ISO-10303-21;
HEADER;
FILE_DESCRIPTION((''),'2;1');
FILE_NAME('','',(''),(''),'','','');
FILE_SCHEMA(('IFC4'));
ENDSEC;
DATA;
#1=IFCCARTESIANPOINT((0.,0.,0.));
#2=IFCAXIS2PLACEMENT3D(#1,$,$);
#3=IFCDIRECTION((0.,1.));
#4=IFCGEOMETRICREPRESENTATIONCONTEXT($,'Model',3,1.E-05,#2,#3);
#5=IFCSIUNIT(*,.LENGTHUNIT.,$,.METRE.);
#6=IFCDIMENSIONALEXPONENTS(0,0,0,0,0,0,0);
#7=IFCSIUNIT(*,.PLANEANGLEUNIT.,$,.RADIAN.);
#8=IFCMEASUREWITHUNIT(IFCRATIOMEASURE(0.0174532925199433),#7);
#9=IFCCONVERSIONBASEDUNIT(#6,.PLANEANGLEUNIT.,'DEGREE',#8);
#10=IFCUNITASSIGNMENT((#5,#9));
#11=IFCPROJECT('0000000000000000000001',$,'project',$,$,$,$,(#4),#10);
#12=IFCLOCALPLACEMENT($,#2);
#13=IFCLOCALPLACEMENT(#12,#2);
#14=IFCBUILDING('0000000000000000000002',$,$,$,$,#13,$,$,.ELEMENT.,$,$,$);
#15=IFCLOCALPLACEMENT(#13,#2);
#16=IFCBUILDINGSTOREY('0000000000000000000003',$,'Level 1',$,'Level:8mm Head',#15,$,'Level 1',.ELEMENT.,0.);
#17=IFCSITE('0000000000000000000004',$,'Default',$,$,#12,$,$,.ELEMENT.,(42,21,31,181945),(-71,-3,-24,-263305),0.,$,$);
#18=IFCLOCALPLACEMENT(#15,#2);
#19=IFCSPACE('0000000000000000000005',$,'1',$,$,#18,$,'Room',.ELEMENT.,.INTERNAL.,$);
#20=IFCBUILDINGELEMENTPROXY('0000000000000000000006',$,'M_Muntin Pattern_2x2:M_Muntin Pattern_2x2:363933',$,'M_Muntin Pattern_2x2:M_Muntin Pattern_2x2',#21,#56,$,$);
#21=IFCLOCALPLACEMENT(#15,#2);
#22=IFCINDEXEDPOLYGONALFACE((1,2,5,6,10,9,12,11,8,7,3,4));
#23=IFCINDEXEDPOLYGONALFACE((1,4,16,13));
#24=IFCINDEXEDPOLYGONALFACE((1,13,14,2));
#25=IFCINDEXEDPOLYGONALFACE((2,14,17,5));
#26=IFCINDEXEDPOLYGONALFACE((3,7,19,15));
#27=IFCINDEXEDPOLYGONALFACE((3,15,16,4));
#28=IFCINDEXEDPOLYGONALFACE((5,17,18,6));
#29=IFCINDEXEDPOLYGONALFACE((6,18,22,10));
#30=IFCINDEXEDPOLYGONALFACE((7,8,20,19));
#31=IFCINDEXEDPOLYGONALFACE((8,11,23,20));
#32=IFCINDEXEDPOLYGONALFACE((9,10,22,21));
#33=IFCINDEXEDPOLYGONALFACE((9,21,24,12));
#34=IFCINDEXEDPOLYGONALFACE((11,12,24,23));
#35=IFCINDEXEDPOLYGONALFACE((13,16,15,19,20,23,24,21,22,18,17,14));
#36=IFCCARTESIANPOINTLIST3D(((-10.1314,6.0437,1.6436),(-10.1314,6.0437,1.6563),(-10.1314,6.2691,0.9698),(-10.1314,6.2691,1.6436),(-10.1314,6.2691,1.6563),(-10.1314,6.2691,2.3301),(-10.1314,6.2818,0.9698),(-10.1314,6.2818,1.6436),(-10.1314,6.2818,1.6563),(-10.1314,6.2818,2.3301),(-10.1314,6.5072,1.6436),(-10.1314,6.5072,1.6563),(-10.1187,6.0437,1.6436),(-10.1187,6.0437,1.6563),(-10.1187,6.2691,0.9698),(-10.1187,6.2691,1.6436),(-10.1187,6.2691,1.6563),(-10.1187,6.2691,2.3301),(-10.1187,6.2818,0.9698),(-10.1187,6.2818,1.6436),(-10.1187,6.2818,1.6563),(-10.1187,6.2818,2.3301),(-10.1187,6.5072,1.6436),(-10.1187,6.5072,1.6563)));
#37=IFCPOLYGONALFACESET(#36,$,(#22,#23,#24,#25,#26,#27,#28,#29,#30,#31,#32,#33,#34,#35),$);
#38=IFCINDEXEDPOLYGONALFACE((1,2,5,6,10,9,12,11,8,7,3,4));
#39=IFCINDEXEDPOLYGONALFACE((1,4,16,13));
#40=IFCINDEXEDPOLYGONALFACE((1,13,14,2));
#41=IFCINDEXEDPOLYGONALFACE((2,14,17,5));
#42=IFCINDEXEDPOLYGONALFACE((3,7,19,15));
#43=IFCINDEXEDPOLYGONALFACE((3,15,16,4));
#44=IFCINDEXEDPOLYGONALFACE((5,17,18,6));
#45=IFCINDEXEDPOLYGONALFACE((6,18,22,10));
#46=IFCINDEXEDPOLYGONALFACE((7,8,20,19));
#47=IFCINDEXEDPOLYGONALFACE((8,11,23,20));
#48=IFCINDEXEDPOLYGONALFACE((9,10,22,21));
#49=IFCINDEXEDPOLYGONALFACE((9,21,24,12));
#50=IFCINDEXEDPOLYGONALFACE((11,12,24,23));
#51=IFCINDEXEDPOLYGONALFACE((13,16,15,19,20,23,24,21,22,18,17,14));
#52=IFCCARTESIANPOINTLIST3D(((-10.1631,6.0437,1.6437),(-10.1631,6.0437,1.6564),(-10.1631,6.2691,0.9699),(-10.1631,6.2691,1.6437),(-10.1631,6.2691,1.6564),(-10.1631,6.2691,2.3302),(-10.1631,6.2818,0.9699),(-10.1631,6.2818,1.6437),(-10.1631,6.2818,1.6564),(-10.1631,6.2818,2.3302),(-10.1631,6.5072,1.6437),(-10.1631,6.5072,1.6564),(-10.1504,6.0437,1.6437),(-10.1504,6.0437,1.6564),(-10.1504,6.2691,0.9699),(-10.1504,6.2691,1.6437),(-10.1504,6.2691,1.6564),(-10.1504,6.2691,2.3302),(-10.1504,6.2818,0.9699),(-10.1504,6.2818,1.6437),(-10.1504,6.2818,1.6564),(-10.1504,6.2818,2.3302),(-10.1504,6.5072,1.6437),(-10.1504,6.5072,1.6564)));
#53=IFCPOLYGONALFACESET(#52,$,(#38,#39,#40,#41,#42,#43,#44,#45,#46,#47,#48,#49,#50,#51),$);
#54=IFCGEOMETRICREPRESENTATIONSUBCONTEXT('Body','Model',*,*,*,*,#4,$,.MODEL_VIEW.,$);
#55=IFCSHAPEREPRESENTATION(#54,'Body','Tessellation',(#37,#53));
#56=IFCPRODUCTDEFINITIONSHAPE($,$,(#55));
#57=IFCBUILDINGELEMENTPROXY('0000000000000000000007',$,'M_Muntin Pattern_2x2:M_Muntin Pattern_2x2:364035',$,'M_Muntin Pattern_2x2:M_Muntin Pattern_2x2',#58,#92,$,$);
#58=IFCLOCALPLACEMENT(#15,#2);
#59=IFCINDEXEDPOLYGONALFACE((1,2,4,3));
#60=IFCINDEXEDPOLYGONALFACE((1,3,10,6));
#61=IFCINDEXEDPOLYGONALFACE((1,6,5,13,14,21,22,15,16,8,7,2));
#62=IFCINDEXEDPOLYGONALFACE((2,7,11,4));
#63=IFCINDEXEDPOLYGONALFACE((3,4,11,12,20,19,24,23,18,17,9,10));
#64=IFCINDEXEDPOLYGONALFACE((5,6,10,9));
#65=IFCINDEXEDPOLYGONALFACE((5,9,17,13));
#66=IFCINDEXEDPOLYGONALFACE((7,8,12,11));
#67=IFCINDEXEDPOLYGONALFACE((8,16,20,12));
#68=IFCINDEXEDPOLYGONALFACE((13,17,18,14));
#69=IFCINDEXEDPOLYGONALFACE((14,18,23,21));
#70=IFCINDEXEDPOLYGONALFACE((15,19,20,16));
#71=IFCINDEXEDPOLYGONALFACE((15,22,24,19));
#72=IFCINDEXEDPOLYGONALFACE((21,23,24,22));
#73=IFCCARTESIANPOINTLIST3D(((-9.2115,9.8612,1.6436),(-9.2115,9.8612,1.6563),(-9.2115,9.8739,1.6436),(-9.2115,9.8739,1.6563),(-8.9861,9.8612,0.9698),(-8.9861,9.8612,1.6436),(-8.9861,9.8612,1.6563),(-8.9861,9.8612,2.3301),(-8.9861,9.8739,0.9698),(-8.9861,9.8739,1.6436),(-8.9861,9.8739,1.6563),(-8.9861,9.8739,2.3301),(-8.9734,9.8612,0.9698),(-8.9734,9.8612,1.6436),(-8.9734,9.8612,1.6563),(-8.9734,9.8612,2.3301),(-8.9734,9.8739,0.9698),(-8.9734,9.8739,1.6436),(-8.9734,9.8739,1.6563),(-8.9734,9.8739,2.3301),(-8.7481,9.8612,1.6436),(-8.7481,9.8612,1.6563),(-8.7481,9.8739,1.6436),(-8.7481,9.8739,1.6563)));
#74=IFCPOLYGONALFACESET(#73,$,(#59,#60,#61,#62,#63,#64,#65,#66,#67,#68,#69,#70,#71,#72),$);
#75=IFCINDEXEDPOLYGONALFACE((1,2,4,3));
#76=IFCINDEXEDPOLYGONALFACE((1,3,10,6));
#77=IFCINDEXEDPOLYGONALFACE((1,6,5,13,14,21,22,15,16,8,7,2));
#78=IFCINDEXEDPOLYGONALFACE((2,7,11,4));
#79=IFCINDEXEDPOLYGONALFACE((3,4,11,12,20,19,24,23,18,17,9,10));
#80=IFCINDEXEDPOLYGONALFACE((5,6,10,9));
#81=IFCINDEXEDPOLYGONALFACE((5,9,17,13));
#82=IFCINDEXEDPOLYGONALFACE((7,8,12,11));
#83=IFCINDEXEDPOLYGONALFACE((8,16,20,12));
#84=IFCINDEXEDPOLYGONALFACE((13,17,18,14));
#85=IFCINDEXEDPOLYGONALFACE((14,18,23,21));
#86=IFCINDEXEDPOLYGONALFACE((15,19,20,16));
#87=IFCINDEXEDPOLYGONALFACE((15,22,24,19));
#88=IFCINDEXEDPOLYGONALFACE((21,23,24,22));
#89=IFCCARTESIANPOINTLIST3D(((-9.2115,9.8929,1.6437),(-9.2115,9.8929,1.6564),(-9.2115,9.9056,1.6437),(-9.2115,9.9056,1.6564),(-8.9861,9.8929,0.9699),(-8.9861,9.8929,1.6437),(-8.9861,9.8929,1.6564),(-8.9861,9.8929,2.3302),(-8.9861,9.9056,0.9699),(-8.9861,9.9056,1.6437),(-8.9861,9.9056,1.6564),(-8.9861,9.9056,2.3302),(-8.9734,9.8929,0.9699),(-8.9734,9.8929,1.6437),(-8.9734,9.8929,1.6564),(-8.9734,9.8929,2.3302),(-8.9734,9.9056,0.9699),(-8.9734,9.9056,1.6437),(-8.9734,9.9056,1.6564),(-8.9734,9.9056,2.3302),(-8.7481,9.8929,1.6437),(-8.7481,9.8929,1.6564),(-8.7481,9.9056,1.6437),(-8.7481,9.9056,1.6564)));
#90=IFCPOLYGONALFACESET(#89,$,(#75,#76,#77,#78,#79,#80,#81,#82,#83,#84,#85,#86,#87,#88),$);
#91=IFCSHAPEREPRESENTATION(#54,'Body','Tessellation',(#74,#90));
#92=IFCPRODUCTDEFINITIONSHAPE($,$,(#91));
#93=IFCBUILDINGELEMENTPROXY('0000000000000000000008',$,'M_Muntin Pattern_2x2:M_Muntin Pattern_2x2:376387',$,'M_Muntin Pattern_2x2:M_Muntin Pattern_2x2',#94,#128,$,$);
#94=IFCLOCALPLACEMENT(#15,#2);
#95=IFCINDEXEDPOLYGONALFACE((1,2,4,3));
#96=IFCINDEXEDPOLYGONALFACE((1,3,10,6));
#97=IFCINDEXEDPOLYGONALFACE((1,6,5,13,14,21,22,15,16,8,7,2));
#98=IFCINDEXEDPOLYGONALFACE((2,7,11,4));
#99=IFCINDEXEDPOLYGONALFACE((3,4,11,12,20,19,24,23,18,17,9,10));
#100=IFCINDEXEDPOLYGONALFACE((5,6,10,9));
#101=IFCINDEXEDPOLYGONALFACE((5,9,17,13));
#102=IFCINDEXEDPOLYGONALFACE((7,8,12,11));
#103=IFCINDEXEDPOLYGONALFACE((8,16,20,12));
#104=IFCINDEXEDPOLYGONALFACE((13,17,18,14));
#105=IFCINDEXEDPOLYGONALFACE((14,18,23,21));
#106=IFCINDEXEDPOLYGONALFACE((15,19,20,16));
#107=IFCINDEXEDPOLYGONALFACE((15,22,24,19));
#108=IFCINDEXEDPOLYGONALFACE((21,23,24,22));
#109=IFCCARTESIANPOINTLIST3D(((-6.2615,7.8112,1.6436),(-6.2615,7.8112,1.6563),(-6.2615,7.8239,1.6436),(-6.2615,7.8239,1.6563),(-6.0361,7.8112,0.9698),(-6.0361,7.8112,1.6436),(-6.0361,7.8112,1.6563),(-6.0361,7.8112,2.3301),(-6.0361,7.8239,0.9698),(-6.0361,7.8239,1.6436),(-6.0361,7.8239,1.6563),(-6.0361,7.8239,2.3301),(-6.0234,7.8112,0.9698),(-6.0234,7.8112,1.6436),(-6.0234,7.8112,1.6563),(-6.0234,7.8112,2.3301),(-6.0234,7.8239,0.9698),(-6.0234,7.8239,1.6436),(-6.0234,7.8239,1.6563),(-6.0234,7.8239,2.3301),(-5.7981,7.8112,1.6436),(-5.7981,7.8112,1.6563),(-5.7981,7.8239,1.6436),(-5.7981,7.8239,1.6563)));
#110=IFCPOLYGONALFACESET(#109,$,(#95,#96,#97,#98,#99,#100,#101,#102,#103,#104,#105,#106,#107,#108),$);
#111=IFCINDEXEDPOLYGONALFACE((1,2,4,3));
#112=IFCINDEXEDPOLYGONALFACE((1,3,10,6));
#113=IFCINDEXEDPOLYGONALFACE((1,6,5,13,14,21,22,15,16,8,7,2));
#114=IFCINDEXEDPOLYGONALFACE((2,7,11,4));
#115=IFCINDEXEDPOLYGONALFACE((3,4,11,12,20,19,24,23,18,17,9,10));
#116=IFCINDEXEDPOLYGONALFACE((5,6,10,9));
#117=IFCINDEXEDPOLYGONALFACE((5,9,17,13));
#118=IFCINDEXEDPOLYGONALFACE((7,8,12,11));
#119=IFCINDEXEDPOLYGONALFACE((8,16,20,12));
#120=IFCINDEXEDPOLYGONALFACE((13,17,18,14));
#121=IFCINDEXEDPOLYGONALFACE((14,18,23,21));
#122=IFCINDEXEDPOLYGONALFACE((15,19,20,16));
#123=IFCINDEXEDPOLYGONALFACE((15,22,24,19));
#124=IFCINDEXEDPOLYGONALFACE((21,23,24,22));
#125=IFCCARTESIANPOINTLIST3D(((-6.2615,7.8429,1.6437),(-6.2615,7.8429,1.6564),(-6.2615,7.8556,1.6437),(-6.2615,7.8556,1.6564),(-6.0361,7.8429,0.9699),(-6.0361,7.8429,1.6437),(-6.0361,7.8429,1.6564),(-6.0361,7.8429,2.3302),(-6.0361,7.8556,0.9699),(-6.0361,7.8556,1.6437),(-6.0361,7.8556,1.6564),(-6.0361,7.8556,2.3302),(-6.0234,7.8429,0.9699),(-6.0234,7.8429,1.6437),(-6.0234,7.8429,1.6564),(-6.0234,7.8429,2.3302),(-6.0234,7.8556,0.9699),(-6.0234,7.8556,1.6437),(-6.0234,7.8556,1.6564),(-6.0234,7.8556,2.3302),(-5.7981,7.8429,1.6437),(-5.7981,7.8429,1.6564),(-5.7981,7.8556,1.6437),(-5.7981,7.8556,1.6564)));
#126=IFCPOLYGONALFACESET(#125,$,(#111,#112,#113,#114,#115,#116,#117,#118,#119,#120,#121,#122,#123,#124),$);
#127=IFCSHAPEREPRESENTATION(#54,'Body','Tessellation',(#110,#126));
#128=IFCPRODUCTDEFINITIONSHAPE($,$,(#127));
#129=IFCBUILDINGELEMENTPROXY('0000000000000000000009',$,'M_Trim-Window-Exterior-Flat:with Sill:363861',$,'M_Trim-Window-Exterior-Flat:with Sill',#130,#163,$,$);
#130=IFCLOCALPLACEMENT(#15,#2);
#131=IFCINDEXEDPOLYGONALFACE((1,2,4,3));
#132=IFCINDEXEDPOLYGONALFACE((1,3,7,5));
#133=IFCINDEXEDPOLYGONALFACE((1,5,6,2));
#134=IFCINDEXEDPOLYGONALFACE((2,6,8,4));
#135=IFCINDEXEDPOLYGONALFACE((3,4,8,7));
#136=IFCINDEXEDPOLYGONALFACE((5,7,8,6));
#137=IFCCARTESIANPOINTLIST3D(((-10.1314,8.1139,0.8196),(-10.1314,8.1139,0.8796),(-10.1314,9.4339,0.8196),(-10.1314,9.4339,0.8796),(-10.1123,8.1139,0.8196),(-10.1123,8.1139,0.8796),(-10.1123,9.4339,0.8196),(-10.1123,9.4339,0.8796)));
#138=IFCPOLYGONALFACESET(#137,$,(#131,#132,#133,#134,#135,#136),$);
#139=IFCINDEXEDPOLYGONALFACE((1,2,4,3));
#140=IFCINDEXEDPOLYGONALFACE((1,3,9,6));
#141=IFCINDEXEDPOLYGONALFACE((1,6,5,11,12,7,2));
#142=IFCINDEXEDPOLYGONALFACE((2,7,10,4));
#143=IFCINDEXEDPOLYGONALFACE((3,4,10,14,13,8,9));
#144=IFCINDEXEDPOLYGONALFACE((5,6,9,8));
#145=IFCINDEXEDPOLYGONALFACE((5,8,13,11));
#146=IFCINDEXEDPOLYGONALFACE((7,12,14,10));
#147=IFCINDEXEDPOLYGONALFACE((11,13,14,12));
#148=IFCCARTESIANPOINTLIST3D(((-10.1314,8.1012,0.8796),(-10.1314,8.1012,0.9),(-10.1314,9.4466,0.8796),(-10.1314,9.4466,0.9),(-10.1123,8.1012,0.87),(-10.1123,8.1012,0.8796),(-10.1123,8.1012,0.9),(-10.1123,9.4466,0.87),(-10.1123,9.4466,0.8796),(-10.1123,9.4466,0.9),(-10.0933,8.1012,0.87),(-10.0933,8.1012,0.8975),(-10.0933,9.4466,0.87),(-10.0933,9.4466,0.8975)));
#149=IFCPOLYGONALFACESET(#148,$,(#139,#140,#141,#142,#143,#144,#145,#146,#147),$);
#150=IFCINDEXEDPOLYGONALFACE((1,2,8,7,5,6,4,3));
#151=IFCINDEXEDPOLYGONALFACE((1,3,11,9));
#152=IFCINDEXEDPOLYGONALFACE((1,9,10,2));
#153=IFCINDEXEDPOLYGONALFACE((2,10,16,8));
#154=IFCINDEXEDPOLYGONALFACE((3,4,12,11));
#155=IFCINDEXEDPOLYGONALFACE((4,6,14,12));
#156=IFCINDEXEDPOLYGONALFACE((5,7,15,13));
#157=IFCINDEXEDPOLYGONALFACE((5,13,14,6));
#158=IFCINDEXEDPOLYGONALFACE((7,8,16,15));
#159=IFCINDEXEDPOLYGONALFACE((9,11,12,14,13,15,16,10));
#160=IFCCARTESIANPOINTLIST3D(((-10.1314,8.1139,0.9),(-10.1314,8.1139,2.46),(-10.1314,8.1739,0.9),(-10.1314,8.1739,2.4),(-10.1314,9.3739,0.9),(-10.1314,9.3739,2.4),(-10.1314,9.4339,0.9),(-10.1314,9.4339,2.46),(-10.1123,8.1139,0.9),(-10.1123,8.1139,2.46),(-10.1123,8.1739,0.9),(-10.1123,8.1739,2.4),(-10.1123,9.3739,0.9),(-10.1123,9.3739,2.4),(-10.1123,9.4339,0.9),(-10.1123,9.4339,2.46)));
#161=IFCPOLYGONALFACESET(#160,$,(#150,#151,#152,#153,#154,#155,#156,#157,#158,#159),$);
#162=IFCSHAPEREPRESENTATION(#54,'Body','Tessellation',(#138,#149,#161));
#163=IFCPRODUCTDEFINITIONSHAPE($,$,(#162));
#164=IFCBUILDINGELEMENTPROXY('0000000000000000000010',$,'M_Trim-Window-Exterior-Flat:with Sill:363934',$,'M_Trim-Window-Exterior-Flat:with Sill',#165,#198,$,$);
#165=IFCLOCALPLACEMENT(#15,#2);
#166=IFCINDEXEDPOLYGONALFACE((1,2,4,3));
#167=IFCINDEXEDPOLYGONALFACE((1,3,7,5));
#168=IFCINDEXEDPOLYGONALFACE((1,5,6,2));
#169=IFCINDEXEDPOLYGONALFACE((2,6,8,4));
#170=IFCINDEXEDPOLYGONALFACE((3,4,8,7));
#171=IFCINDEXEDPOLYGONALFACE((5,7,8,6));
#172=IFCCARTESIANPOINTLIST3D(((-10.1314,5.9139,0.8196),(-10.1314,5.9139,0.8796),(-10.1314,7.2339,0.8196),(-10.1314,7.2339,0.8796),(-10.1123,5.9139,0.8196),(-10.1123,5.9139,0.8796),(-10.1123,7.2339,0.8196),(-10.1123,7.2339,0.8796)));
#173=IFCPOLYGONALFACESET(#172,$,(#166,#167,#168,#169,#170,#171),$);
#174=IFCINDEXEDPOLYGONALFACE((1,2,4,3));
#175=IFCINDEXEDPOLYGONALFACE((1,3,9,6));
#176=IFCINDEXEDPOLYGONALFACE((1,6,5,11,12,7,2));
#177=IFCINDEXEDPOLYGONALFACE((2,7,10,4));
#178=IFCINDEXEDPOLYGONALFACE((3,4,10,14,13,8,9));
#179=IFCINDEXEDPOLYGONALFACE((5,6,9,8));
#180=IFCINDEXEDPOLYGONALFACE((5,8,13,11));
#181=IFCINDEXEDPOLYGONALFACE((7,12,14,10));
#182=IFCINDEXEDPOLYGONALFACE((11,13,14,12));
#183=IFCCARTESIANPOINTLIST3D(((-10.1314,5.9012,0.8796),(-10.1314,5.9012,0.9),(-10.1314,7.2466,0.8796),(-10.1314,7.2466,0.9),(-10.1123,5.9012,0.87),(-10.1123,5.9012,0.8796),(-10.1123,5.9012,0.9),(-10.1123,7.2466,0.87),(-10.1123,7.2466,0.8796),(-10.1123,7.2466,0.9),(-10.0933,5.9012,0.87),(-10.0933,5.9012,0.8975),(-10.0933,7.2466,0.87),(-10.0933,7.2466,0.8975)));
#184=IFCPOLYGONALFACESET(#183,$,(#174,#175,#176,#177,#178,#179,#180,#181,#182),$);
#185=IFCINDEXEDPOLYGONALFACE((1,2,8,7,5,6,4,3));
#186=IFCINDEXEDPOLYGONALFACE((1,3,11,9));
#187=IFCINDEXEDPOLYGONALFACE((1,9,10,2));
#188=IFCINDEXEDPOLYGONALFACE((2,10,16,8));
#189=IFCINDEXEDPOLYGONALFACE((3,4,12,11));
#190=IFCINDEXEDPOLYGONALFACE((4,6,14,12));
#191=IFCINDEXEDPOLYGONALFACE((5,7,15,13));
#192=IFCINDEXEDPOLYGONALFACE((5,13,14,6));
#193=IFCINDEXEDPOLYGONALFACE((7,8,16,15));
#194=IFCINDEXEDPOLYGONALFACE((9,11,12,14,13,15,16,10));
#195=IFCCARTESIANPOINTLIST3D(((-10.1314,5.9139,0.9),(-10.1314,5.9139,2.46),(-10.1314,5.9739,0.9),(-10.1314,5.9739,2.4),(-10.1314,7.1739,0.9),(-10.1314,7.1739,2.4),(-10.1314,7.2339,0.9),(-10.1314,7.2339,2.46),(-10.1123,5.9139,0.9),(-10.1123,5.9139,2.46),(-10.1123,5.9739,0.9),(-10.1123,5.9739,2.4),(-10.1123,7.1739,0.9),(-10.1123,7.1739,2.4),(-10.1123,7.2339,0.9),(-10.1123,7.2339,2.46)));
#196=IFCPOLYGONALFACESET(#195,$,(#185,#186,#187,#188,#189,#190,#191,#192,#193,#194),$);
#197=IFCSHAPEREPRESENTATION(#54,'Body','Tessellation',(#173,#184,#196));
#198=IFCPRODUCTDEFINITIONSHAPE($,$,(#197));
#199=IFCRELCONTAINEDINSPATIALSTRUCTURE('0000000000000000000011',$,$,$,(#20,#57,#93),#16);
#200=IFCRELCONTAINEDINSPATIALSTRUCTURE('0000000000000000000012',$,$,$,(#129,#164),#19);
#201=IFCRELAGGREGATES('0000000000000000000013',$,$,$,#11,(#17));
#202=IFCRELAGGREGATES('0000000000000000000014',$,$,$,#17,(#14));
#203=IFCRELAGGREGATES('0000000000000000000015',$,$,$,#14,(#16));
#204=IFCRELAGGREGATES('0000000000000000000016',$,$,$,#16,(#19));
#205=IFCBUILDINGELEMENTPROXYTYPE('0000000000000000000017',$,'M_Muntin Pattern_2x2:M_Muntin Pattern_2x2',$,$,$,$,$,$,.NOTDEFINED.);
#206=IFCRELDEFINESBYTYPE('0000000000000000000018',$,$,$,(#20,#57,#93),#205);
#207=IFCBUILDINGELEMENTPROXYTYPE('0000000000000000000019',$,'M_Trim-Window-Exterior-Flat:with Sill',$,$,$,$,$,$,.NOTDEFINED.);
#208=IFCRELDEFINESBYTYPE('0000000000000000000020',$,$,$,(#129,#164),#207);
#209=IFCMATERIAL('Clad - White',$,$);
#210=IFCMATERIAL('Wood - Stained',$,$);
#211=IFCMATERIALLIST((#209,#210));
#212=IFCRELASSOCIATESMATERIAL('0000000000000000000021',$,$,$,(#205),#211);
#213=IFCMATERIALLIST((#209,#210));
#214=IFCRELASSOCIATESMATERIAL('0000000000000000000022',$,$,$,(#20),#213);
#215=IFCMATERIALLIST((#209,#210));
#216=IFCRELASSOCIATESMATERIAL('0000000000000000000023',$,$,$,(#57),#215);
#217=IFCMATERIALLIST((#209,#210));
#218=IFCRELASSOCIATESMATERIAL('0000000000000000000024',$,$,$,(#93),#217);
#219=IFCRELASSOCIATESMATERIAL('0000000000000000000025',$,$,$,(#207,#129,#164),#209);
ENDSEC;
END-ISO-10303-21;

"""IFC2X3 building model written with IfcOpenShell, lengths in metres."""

from ifc_helpers import new_model, entity, si_unit, converted_unit, direction, frame, frame_2d, origin, place, context, subcontext, project, spatial, polyline, rectangle, outline, extrude, source, transform, mapped, material, material_list, type_object, type_shapes, element, save


model = new_model("IFC2X3")

# Units and contexts
model_context = context("Model", 3, precision=1e-05, world=origin(), true_north=direction((0.0, 1.0)))
body_context = subcontext(model_context, "Body", "Model", "MODEL_VIEW")
ifc_project = project(units=[si_unit("LENGTHUNIT", "METRE"), converted_unit("PLANEANGLEUNIT", "DEGREE", entity("IfcRatioMeasure", 0.0174532925199433), si_unit("PLANEANGLEUNIT", "RADIAN"), dimensions=[0, 0, 0, 0, 0, 0, 0])], contexts=[model_context])

# Site, building, storey
site_placement = place(None, origin())
site = spatial("IfcSite", under=ifc_project, at=site_placement, Name="Default", CompositionType="ELEMENT", RefLatitude=(42, 21, 31, 181945), RefLongitude=(-71, -3, -24, -263305), RefElevation=0.0)
building_placement = place(site_placement, origin())
building = spatial("IfcBuilding", under=site, at=building_placement, CompositionType="ELEMENT")
storey_placement = place(building_placement, origin())
storey = spatial("IfcBuildingStorey", under=building, at=storey_placement, Name="Level 1", ObjectType="Level:8mm Head", LongName="Level 1", CompositionType="ELEMENT", Elevation=0.0)

# Building element proxies
ifc_material_1 = material(Name="Clad - White")
ifc_material_2 = material(Name="Wood - Stained")
ifc_material_list_1 = material_list([ifc_material_1, ifc_material_2])
building_element_proxy_type_1 = type_object("IfcBuildingElementProxyType", Name="M_Muntin Pattern_2x2:M_Muntin Pattern_2x2", PredefinedType="NOTDEFINED", material=ifc_material_list_1)
shared_shape_1 = source(origin(), body_context, "Body", "SweptSolid", [
    extrude(outline(polyline([(0.0064, -0.0064), (0.6801, -0.0064), (0.6801, 0.0063), (0.0064, 0.0063), (0.0064, 0.2317), (-0.0063, 0.2317), (-0.0063, 0.0063), (-0.6802, 0.0063), (-0.6802, -0.0064), (-0.0063, -0.0064), (-0.0063, -0.2317), (0.0064, -0.2317), (0.0064, -0.0064)])), frame((0.0, -0.0222, 0.6801), z_axis=(0.0, 1.0, 0.0), x_axis=(0.0, 0.0, 1.0)), (0.0, 0.0, 1.0), 0.0127),
    extrude(outline(polyline([(0.0064, -0.0064), (0.6802, -0.0064), (0.6802, 0.0063), (0.0064, 0.0063), (0.0064, 0.2317), (-0.0063, 0.2317), (-0.0063, 0.0063), (-0.6802, 0.0063), (-0.6802, -0.0064), (-0.0063, -0.0064), (-0.0063, -0.2317), (0.0064, -0.2317), (0.0064, -0.0064)])), frame((0.0, 0.0095, 0.6802), z_axis=(0.0, 1.0, 0.0), x_axis=(0.0, 0.0, 1.0)), (0.0, 0.0, 1.0), 0.0127),
])
type_shapes(building_element_proxy_type_1, [shared_shape_1])
ifc_material_list_2 = material_list([ifc_material_1, ifc_material_2])
proxy_1_placement = place(storey_placement, frame((-10.1409, 6.2754, 0.9699), z_axis=(0.0, 0.0, 1.0), x_axis=(0.0, 1.0, 0.0)))
element("IfcBuildingElementProxy", 1, at=proxy_1_placement, inside=storey, type_object=building_element_proxy_type_1, material=ifc_material_list_2, Name="M_Muntin Pattern_2x2:M_Muntin Pattern_2x2:363933", ObjectType="M_Muntin Pattern_2x2:M_Muntin Pattern_2x2", context=body_context, shape_type="MappedRepresentation", body=[
    mapped(shared_shape_1, transform((0.0, 0.0, 0.0), scale=1.0)),
])
ifc_material_list_3 = material_list([ifc_material_1, ifc_material_2])
proxy_2_placement = place(storey_placement, frame((-8.9798, 9.8834, 0.9699)))
element("IfcBuildingElementProxy", 2, at=proxy_2_placement, inside=storey, type_object=building_element_proxy_type_1, material=ifc_material_list_3, Name="M_Muntin Pattern_2x2:M_Muntin Pattern_2x2:364035", ObjectType="M_Muntin Pattern_2x2:M_Muntin Pattern_2x2", context=body_context, shape_type="MappedRepresentation", body=[
    mapped(shared_shape_1, transform((0.0, 0.0, 0.0), scale=1.0)),
])
ifc_material_list_4 = material_list([ifc_material_1, ifc_material_2])
proxy_3_placement = place(storey_placement, frame((-6.0298, 7.8334, 0.9699)))
element("IfcBuildingElementProxy", 3, at=proxy_3_placement, inside=storey, type_object=building_element_proxy_type_1, material=ifc_material_list_4, Name="M_Muntin Pattern_2x2:M_Muntin Pattern_2x2:376387", ObjectType="M_Muntin Pattern_2x2:M_Muntin Pattern_2x2", context=body_context, shape_type="MappedRepresentation", body=[
    mapped(shared_shape_1, transform((0.0, 0.0, 0.0), scale=1.0)),
])

# Shared definitions
space_1_placement = place(storey_placement, origin())
space_1 = spatial("IfcSpace", under=storey, at=space_1_placement, Name="1", LongName="Room", CompositionType="ELEMENT", InteriorOrExteriorSpace="INTERNAL")

# Building element proxies
building_element_proxy_type_2 = type_object("IfcBuildingElementProxyType", Name="M_Trim-Window-Exterior-Flat:with Sill", PredefinedType="NOTDEFINED", material=ifc_material_1)
shared_shape_2 = source(origin(), body_context, "Body", "SweptSolid", [
    extrude(rectangle(XDim=1.32, YDim=0.06, at=frame_2d((0.0, 0.0), x_axis=(1.0, 0.0))), frame((0.0, -1.5504, 0.0), z_axis=(0.0, 0.0, 1.0), x_axis=(-1.0, 0.0, 0.0)), (0.0, 0.0, 1.0), 0.0191),
    extrude(outline(polyline([(-0.019, -0.0152), (0.0, -0.0152), (0.0, -0.0057), (0.019, -0.0057), (0.019, 0.0148), (0.0, 0.0148), (-0.019, 0.0123), (-0.019, -0.0152)])), frame((-0.6727, -1.5148, 0.019), z_axis=(1.0, 0.0, 0.0), x_axis=(0.0, 0.0, -1.0)), (0.0, 0.0, 1.0), 1.3454),
    extrude(outline(polyline([(-0.795, -0.66), (0.765, -0.66), (0.765, -0.6), (-0.735, -0.6), (-0.735, 0.6), (0.765, 0.6), (0.765, 0.66), (-0.795, 0.66), (-0.795, -0.66)])), frame((0.0, -0.735, 0.0), z_axis=(0.0, 0.0, 1.0), x_axis=(0.0, -1.0, 0.0)), (0.0, 0.0, 1.0), 0.0191),
])
type_shapes(building_element_proxy_type_2, [shared_shape_2])
for number, where, z_axis, x_axis, name in (
    (4, (-10.1314, 8.7739, 2.4), (1.0, 0.0, 0.0), (0.0, 1.0, 0.0), "M_Trim-Window-Exterior-Flat:with Sill:363861"),
    (5, (-10.1314, 6.5739, 2.4), (1.0, 0.0, 0.0), (0.0, 1.0, 0.0), "M_Trim-Window-Exterior-Flat:with Sill:363934"),
):
    element("IfcBuildingElementProxy", number, at=place(space_1_placement, frame(where, z_axis=z_axis, x_axis=x_axis)), inside=space_1, type_object=building_element_proxy_type_2, material=ifc_material_1, Name=name, ObjectType="M_Trim-Window-Exterior-Flat:with Sill", context=body_context, shape_type="MappedRepresentation", body=[
        mapped(shared_shape_2, transform((0.0, 0.0, 0.0), scale=1.0)),
    ])

save(model, "model.ifc")
